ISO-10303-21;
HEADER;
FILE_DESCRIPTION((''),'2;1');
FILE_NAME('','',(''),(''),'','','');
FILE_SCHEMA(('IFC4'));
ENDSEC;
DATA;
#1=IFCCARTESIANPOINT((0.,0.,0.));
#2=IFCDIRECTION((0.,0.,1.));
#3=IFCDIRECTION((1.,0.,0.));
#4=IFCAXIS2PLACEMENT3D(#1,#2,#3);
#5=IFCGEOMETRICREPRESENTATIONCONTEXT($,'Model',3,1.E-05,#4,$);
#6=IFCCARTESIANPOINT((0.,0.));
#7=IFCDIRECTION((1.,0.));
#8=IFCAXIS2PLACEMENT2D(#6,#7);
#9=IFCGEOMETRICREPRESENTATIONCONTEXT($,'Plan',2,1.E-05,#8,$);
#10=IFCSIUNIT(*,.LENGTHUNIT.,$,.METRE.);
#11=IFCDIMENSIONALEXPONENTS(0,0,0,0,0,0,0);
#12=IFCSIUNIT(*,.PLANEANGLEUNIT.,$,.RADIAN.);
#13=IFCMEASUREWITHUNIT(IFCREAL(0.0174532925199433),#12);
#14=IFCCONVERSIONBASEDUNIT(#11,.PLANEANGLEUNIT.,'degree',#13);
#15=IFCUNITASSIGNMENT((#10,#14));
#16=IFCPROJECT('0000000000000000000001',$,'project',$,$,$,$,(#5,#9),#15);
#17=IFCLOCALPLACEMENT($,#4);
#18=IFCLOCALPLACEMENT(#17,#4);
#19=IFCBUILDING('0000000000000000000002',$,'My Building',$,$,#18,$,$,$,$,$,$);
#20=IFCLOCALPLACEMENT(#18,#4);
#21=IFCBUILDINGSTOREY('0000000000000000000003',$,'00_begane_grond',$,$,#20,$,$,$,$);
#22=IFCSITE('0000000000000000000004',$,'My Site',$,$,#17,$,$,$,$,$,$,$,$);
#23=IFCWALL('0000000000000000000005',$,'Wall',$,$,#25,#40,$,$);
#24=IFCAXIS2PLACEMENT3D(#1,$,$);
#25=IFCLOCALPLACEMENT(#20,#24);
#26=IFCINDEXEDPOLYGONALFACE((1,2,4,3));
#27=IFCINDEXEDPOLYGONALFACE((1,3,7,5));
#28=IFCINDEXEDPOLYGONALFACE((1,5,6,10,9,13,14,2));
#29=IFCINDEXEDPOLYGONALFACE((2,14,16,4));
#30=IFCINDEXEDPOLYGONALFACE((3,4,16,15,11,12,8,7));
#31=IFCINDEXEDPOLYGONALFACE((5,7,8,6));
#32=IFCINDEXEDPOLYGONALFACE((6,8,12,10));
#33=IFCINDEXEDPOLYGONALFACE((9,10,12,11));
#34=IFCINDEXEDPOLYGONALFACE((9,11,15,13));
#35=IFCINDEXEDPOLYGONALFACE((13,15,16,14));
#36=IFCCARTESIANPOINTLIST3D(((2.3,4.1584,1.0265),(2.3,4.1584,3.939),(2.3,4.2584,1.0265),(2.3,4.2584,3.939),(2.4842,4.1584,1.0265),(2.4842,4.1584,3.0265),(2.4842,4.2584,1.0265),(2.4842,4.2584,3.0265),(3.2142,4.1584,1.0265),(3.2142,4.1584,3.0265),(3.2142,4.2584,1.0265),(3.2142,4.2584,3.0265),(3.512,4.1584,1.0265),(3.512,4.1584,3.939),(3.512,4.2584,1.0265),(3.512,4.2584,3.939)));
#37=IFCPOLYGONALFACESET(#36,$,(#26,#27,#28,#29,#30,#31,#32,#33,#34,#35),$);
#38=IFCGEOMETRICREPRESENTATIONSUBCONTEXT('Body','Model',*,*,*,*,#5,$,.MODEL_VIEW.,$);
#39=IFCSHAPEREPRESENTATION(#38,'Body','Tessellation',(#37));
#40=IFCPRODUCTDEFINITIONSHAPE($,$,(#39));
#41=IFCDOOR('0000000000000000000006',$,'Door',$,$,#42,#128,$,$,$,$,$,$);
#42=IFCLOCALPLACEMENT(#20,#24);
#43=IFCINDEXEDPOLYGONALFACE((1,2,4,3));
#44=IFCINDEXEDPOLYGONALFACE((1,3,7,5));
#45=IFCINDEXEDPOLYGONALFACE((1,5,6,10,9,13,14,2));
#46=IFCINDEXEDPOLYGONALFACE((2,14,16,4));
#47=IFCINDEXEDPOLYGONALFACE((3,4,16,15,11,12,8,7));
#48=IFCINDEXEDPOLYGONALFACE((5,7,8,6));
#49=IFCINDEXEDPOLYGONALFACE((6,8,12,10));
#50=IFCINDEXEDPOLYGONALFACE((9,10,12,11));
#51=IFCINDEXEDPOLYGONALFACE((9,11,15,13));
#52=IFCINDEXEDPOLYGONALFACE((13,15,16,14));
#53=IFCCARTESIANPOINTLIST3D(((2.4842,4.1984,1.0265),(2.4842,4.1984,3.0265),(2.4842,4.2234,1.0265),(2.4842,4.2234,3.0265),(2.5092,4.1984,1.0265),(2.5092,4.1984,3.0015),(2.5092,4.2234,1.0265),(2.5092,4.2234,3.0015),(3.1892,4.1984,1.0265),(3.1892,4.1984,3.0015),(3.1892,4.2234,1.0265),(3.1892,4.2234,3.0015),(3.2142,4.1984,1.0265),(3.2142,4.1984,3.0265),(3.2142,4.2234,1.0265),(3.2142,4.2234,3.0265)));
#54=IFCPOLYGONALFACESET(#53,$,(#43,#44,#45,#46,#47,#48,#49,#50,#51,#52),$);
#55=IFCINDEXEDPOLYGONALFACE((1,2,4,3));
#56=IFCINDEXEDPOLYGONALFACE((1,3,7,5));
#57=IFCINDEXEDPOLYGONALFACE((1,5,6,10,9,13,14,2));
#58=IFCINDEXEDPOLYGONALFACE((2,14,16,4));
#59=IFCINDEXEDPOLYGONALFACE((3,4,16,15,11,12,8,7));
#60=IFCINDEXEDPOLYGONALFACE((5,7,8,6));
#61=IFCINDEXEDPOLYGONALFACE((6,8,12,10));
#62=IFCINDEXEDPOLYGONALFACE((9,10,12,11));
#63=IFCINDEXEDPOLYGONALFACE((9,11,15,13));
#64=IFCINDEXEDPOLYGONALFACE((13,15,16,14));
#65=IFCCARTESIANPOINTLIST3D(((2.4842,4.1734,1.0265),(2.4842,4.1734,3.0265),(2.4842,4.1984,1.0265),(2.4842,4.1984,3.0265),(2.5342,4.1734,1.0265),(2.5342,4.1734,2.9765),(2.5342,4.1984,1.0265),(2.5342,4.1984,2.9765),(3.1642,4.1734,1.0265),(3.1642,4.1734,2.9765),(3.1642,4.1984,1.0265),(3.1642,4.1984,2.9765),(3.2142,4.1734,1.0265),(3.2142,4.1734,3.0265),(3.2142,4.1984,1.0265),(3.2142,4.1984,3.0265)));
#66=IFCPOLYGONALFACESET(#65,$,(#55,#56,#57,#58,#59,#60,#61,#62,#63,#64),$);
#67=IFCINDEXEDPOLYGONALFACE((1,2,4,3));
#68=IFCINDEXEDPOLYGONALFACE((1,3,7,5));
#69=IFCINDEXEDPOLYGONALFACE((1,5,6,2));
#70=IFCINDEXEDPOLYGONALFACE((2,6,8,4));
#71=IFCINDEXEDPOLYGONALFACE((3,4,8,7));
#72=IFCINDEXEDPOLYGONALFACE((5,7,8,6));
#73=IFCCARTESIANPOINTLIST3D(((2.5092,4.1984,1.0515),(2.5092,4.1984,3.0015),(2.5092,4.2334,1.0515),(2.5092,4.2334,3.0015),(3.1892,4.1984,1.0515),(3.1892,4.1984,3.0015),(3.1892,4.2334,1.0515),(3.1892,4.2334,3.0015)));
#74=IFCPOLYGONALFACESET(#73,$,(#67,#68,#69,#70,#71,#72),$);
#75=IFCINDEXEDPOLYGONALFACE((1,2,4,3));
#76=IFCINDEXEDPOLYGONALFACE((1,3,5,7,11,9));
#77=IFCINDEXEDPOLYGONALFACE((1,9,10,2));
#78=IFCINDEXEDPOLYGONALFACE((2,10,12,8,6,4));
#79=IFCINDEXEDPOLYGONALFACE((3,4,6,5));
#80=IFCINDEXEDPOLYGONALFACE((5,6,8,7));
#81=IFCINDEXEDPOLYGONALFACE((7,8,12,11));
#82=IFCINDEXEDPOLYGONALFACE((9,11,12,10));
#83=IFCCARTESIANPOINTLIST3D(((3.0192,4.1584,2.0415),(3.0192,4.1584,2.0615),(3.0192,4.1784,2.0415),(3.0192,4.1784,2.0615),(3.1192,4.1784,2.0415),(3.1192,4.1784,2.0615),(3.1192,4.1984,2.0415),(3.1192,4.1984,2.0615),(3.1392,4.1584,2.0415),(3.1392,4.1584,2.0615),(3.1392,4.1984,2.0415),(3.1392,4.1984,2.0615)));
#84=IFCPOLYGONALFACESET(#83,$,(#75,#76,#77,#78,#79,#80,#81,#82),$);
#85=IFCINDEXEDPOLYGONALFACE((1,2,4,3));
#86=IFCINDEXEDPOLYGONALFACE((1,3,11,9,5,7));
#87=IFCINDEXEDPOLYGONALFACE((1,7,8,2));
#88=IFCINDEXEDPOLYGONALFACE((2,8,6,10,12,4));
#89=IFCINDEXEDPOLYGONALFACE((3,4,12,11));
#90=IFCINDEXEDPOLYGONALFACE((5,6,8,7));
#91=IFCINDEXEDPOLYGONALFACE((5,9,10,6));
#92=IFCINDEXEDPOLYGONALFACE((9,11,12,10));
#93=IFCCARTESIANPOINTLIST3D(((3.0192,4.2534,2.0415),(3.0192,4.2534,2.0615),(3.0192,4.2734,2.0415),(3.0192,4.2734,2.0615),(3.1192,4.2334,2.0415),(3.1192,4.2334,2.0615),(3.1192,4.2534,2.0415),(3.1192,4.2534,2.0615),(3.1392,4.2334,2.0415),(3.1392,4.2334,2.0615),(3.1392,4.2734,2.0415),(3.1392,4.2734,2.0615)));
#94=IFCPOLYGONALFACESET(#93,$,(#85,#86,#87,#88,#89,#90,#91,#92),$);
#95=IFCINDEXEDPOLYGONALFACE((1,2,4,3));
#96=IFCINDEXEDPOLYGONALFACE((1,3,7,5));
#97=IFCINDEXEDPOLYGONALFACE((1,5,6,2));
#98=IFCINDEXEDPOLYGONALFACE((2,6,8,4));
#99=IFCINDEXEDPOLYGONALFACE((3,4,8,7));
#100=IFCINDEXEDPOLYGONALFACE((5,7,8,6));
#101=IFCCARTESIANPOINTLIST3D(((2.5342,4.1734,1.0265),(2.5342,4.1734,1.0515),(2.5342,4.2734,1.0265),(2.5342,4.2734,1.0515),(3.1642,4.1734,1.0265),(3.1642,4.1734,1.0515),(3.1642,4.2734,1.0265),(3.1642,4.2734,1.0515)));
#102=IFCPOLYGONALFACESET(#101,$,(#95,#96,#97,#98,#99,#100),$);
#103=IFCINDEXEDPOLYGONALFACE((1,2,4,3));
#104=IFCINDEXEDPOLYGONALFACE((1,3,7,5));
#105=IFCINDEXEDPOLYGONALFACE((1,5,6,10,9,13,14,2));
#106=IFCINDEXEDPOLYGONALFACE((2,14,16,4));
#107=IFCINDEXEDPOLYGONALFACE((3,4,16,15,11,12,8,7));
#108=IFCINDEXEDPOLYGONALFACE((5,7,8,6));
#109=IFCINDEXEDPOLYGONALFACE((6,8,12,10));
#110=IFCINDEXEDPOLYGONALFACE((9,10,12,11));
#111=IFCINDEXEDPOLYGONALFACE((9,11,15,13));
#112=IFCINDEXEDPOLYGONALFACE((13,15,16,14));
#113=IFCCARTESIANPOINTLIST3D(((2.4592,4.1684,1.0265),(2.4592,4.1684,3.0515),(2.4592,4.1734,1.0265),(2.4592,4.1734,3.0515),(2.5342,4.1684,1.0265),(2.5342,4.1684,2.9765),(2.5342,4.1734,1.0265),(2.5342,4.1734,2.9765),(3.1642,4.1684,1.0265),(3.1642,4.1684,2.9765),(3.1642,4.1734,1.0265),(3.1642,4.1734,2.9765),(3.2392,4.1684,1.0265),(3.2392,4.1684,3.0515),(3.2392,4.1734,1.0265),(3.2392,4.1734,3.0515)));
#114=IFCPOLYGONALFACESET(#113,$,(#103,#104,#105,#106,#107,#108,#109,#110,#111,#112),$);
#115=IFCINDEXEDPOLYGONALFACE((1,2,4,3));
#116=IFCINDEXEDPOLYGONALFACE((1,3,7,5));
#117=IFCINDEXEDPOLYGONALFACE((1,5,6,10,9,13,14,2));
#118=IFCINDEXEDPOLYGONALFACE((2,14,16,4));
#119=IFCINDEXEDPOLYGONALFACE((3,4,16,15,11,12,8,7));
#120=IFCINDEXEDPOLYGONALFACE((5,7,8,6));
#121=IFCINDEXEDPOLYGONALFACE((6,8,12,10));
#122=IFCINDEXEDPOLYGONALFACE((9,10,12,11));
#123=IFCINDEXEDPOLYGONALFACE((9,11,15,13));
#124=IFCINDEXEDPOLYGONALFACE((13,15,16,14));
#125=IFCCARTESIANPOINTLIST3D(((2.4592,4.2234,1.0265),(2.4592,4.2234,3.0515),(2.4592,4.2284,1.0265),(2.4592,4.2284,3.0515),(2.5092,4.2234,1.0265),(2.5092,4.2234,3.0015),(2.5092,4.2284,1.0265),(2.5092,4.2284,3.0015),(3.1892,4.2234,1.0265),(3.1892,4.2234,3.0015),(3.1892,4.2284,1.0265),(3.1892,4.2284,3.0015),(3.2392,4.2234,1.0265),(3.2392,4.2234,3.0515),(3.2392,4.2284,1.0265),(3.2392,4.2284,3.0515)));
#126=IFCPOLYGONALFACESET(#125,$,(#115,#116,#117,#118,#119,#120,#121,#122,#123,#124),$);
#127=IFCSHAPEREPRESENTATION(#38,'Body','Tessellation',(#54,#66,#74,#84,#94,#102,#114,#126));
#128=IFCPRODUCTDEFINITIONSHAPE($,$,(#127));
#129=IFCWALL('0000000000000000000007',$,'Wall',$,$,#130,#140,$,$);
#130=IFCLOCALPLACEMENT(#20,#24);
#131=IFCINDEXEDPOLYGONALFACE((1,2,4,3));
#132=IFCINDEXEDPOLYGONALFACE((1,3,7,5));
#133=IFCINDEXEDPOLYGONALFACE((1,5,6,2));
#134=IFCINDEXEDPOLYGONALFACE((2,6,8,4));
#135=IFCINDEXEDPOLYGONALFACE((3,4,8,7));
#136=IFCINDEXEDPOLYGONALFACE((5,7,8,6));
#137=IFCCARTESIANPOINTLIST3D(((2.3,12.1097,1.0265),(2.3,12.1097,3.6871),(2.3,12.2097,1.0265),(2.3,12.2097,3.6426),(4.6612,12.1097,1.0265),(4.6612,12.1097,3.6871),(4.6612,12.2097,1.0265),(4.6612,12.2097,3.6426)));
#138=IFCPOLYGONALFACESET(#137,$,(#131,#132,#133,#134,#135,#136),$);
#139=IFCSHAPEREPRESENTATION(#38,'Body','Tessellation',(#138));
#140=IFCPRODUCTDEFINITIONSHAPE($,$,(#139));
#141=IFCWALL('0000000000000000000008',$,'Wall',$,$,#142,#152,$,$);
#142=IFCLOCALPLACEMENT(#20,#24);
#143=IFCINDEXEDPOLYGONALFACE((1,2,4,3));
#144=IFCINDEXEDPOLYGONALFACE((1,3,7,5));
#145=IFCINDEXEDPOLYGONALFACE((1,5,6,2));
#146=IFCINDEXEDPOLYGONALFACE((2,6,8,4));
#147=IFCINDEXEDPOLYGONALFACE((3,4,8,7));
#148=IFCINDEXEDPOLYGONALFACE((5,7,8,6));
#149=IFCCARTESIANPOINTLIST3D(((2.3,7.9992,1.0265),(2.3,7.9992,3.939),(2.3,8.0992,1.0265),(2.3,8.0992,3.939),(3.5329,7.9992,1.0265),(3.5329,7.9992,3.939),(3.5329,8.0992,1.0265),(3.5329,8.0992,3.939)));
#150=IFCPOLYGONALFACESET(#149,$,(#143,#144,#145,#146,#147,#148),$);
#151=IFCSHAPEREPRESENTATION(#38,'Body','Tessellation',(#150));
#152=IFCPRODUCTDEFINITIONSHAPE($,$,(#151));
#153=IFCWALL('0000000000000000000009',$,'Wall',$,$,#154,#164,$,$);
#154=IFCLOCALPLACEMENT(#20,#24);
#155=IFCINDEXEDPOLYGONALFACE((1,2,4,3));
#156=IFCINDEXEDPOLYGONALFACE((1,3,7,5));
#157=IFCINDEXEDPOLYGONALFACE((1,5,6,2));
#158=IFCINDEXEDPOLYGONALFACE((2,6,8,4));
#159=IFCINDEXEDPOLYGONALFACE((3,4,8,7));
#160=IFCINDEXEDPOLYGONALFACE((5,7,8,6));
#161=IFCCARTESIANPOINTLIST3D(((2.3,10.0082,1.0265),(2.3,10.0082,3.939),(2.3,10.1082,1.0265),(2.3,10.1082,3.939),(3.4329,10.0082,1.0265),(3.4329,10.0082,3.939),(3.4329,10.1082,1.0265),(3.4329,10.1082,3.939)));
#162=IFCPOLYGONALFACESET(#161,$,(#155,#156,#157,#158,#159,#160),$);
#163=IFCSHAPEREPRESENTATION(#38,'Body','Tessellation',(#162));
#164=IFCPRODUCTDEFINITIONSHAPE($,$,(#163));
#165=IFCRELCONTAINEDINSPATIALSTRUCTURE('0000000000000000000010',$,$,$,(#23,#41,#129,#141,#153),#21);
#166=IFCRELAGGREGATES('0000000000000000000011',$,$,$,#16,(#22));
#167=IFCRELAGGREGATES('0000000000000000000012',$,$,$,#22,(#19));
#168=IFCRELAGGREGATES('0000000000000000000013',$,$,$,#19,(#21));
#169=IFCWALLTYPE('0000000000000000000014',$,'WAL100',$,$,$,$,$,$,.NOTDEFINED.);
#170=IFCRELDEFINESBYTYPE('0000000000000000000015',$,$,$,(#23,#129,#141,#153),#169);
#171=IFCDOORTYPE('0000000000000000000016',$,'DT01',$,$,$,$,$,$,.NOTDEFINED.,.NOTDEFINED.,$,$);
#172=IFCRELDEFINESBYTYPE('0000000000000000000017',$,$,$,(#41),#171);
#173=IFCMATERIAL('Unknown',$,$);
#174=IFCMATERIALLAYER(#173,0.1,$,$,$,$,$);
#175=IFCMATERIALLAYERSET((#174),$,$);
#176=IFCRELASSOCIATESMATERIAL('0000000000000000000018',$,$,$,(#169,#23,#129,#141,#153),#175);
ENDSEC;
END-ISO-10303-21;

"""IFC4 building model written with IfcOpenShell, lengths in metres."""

from ifc_helpers import new_model, entity, si_unit, converted_unit, frame, origin_with_axes, origin_2d_with_axis, place, context, subcontext, project, spatial, line, indexed_curve, outline, extrude, clip, halfspace, shape, source, transform, mapped, material, layer, layer_set, layer_usage, type_object, type_shapes, element, fill, save


model = new_model("IFC4")

# Units and contexts
model_context = context("Model", 3, precision=1e-05, world=origin_with_axes())
plan_context = context("Plan", 2, precision=1e-05, world=origin_2d_with_axis())
body_context_1 = subcontext(model_context, "Body", "Model", "MODEL_VIEW")
body_context_2 = subcontext(plan_context, "Body", "Plan", "PLAN_VIEW")
ifc_project = project(units=[si_unit("LENGTHUNIT", "METRE"), converted_unit("PLANEANGLEUNIT", "degree", entity("IfcReal", 0.0174532925199433), si_unit("PLANEANGLEUNIT", "RADIAN"), dimensions=[0, 0, 0, 0, 0, 0, 0])], contexts=[model_context, plan_context])

# Site, building, storey
site_placement = place(None, origin_with_axes())
site = spatial("IfcSite", under=ifc_project, at=site_placement, Name="My Site")
building_placement = place(site_placement, origin_with_axes())
building = spatial("IfcBuilding", under=site, at=building_placement, Name="My Building")
storey_placement = place(building_placement, origin_with_axes())
storey = spatial("IfcBuildingStorey", under=building, at=storey_placement, Name="00_begane_grond")

# Shared definitions
ifc_material_1 = material(Name="Unknown")

# Shared definitions
ifc_layer_1 = layer(ifc_material_1, 0.1)
ifc_layer_set_1 = layer_set([ifc_layer_1])
wall_type_1 = type_object("IfcWallType", Name="WAL100", PredefinedType="NOTDEFINED", material=ifc_layer_set_1)

# Wall, opening, door
ifc_layer_usage_1 = layer_usage(ifc_layer_set_1, "AXIS2", "POSITIVE", 0.0)
wall_1_placement = place(storey_placement, frame((3.512, 4.2584, 1.0265), z_axis=(0.0, 0.0, 1.0), x_axis=(-1.0, 0.0, 0.0)))
wall_1 = element("IfcWall", 1, at=wall_1_placement, inside=storey, type_object=wall_type_1, material=ifc_layer_usage_1, Name="Wall", context=body_context_1, shape_type="Clipping", body=[
    clip(extrude(outline(indexed_curve([(0.0, 0.0), (0.0, 0.1), (1.212, 0.1), (1.212, 0.0), (0.0, 0.0)], self_intersect=False)), origin_with_axes(), (0.0, 0.0, 1.0), 3.939), halfspace(frame((0.0, 0.0, 2.9125), z_axis=(0.0, 0.0, 1.0), x_axis=(-1.0, 0.0, 0.0)), False)),
])
shared_shape_1 = source(origin_with_axes(), body_context_1, "Body", "SweptSolid", [
    extrude(outline(indexed_curve([(0.0, 0.0), (0.73, 0.0), (0.73, 2.0), (0.0, 2.0)], segments=[line(1, 2, 3, 4, 1)])), frame((0.0, -0.1, 0.0), z_axis=(0.0, -1.0, 0.0), x_axis=(1.0, 0.0, 0.0)), (0.0, 0.0, -1.0), 0.3),
])
opening_1_placement = place(wall_1_placement, frame((0.2978, 0.0, 0.0), z_axis=(0.0, 0.0, 1.0), x_axis=(1.0, 0.0, 0.0)))
opening_1 = element("IfcOpeningElement", 2, at=opening_1_placement, cuts=wall_1, PredefinedType="OPENING", context=body_context_1, shape_type="MappedRepresentation", body=[
    mapped(shared_shape_1, transform((0.0, 0.0, 0.0), x_axis=(1.0, 0.0, 0.0), y_axis=(0.0, 1.0, 0.0), z_axis=(0.0, 0.0, 1.0), scale=1.0)),
])
door_type_1 = type_object("IfcDoorType", Name="DT01", OperationType="NOTDEFINED", PredefinedType="NOTDEFINED")
shared_shape_2 = source(origin_with_axes(), body_context_1, "Body", "SweptSolid", [
    extrude(outline(indexed_curve([(0.025, 0.0), (0.025, 1.975), (0.705, 1.975), (0.705, 0.0), (0.73, 0.0), (0.73, 2.0), (0.0, 2.0), (0.0, 0.0)], segments=[line(3, 2), line(2, 1), line(1, 8), line(8, 7), line(7, 6), line(6, 5), line(5, 4), line(4, 3)], self_intersect=False)), frame((0.0, 0.025, 0.0), z_axis=(0.0, -1.0, 0.0), x_axis=(1.0, 0.0, 0.0)), (0.0, 0.0, -1.0), 0.025),
    extrude(outline(indexed_curve([(0.0, 0.0), (0.0, 2.0), (0.73, 2.0), (0.73, 0.0), (0.68, 0.0), (0.68, 1.95), (0.05, 1.95), (0.05, 0.0)], segments=[line(1, 2, 3, 4, 5, 6, 7, 8, 1)])), frame((0.0, 0.0, 0.0), z_axis=(0.0, -1.0, 0.0), x_axis=(1.0, 0.0, 0.0)), (0.0, 0.0, -1.0), 0.025),
    extrude(outline(indexed_curve([(0.0, 0.0), (0.68, 0.0), (0.68, 0.035), (0.0, 0.035)], segments=[line(1, 2, 3, 4, 1)])), frame((0.025, 0.025, 0.025), z_axis=(0.0, 0.0, 1.0), x_axis=(1.0, 0.0, 0.0)), (0.0, 0.0, 1.0), 1.95),
    extrude(outline(indexed_curve([(0.0, 0.0), (0.0, -0.04), (-0.12, -0.04), (-0.12, -0.02), (-0.02, -0.02), (-0.02, 0.0)], segments=[line(1, 2, 3, 4, 5, 6, 1)])), frame((0.655, 0.025, 1.015), z_axis=(0.0, 0.0, 1.0), x_axis=(1.0, 0.0, 0.0)), (0.0, 0.0, 1.0), 0.02),
    extrude(outline(indexed_curve([(0.0, 0.0), (0.0, 0.04), (-0.12, 0.04), (-0.12, 0.02), (-0.02, 0.02), (-0.02, 0.0)], segments=[line(1, 2, 3, 4, 5, 6, 1)])), frame((0.655, 0.06, 1.015), z_axis=(0.0, 0.0, 1.0), x_axis=(1.0, 0.0, 0.0)), (0.0, 0.0, 1.0), 0.02),
    extrude(outline(indexed_curve([(0.0, 0.0), (0.63, 0.0), (0.63, 0.1), (0.0, 0.1)], segments=[line(1, 2, 3, 4, 1)])), frame((0.05, 0.0, 0.0), z_axis=(0.0, 0.0, 1.0), x_axis=(1.0, 0.0, 0.0)), (0.0, 0.0, 1.0), 0.025),
    extrude(outline(indexed_curve([(0.0, 0.0), (0.0, 2.025), (0.78, 2.025), (0.78, 0.0), (0.705, 0.0), (0.705, 1.95), (0.075, 1.95), (0.075, 0.0)], segments=[line(1, 2, 3, 4, 5, 6, 7, 8, 1)])), frame((-0.025, -0.005, 0.0), z_axis=(0.0, -1.0, 0.0), x_axis=(1.0, 0.0, 0.0)), (0.0, 0.0, -1.0), 0.005),
    extrude(outline(indexed_curve([(0.0, 0.0), (0.0, 2.025), (0.78, 2.025), (0.78, 0.0), (0.73, 0.0), (0.73, 1.975), (0.05, 1.975), (0.05, 0.0)], segments=[line(1, 2, 3, 4, 5, 6, 7, 8, 1)])), frame((-0.025, 0.05, 0.0), z_axis=(0.0, -1.0, 0.0), x_axis=(1.0, 0.0, 0.0)), (0.0, 0.0, -1.0), 0.005),
])
shared_shape_3 = source(origin_with_axes(), body_context_2, "Body", "Curve2D", [
    entity("IfcIndexedPolyCurve", entity("IfcCartesianPointList2D", [[0.0, 0.0], [0.0, 0.05], [0.025, 0.05], [0.025, 0.025], [0.05, 0.025], [0.05, 0.0]]), [entity("IfcLineIndex", [1, 2, 3, 4, 5, 6, 1])]),
    entity("IfcIndexedPolyCurve", entity("IfcCartesianPointList2D", [[0.73, 0.0], [0.73, 0.05], [0.705, 0.05], [0.705, 0.025], [0.68, 0.025], [0.68, 0.0]]), [entity("IfcLineIndex", [1, 2, 3, 4, 5, 6, 1])]),
    entity("IfcTrimmedCurve", entity("IfcEllipse", entity("IfcAxis2Placement2D", entity("IfcCartesianPoint", [0.06, 0.05]), entity("IfcDirection", [1.0, 0.0])), 0.645, 0.68), [entity("IfcCartesianPoint", [0.705, 0.05])], [entity("IfcCartesianPoint", [0.06, 0.73])], True, "CARTESIAN"),
    entity("IfcIndexedPolyCurve", entity("IfcCartesianPointList2D", [[0.025, 0.05], [0.06, 0.05], [0.06, 0.73], [0.025, 0.73]]), [entity("IfcLineIndex", [1, 2, 3, 4, 1])]),
])
type_shapes(door_type_1, [shared_shape_2, shared_shape_3])
door_1_placement = place(opening_1_placement, frame((0.73, 0.085, 0.0), z_axis=(0.0, 0.0, 1.0), x_axis=(-1.0, 0.0, 0.0)))
door_1 = element("IfcDoor", 3, at=door_1_placement, inside=storey, type_object=door_type_1, Name="Door", shapes=[
    shape(body_context_1, "Body", "MappedRepresentation", [mapped(shared_shape_2, transform((0.0, 0.0, 0.0), x_axis=(1.0, 0.0, 0.0), y_axis=(0.0, 1.0, 0.0), z_axis=(0.0, 0.0, 1.0), scale=1.0))]),
    shape(body_context_2, "Body", "MappedRepresentation", [mapped(shared_shape_3, transform((0.0, 0.0, 0.0), x_axis=(1.0, 0.0, 0.0), y_axis=(0.0, 1.0, 0.0), z_axis=(0.0, 0.0, 1.0), scale=1.0))]),
])
fill(opening_1, door_1)

# Walls
ifc_layer_usage_2 = layer_usage(ifc_layer_set_1, "AXIS2", "POSITIVE", 0.0)
wall_2_placement = place(storey_placement, frame((2.3, 12.1097, 1.0265), z_axis=(0.0, 0.0, 1.0), x_axis=(1.0, -0.000001, 0.0)))
element("IfcWall", 4, at=wall_2_placement, inside=storey, type_object=wall_type_1, material=ifc_layer_usage_2, Name="Wall", context=body_context_1, shape_type="Clipping", body=[
    clip(extrude(outline(indexed_curve([(0.0, 0.0), (0.0, 0.1), (2.3611, 0.1), (2.3611, 0.0), (0.0, 0.0)], self_intersect=False)), origin_with_axes(), (0.0, 0.0, 1.0), 3.6871), halfspace(frame((2.3611, 0.0, 2.6606), z_axis=(0.0, 0.406737, 0.913545), x_axis=(1.0, 0.000001, 0.0)), False)),
])
ifc_layer_usage_3 = layer_usage(ifc_layer_set_1, "AXIS2", "POSITIVE", 0.0)
wall_3_placement = place(storey_placement, frame((2.3, 7.9992, 1.0265), z_axis=(0.0, 0.0, 1.0), x_axis=(1.0, -0.000001, 0.0)))
element("IfcWall", 5, at=wall_3_placement, inside=storey, type_object=wall_type_1, material=ifc_layer_usage_3, Name="Wall", context=body_context_1, shape_type="Clipping", body=[
    clip(extrude(outline(indexed_curve([(0.0, 0.0), (0.0, 0.1), (1.2329, 0.1), (1.2329, 0.0), (0.0, 0.0)], self_intersect=False)), origin_with_axes(), (0.0, 0.0, 1.0), 3.939), halfspace(frame((0.0, 0.0, 2.9125), z_axis=(0.0, 0.0, 1.0), x_axis=(-1.0, 0.0, 0.0)), False)),
])
ifc_layer_usage_4 = layer_usage(ifc_layer_set_1, "AXIS2", "POSITIVE", 0.0)
wall_4_placement = place(storey_placement, frame((2.3, 10.0082, 1.0265), z_axis=(0.0, 0.0, 1.0), x_axis=(1.0, -0.000001, 0.0)))
element("IfcWall", 6, at=wall_4_placement, inside=storey, type_object=wall_type_1, material=ifc_layer_usage_4, Name="Wall", context=body_context_1, shape_type="SweptSolid", body=[
    extrude(outline(indexed_curve([(0.0, 0.0), (0.0, 0.1), (1.1329, 0.1), (1.1329, 0.0), (0.0, 0.0)], self_intersect=False)), origin_with_axes(), (0.0, 0.0, 1.0), 2.9125),
])

save(model, "model.ifc")
